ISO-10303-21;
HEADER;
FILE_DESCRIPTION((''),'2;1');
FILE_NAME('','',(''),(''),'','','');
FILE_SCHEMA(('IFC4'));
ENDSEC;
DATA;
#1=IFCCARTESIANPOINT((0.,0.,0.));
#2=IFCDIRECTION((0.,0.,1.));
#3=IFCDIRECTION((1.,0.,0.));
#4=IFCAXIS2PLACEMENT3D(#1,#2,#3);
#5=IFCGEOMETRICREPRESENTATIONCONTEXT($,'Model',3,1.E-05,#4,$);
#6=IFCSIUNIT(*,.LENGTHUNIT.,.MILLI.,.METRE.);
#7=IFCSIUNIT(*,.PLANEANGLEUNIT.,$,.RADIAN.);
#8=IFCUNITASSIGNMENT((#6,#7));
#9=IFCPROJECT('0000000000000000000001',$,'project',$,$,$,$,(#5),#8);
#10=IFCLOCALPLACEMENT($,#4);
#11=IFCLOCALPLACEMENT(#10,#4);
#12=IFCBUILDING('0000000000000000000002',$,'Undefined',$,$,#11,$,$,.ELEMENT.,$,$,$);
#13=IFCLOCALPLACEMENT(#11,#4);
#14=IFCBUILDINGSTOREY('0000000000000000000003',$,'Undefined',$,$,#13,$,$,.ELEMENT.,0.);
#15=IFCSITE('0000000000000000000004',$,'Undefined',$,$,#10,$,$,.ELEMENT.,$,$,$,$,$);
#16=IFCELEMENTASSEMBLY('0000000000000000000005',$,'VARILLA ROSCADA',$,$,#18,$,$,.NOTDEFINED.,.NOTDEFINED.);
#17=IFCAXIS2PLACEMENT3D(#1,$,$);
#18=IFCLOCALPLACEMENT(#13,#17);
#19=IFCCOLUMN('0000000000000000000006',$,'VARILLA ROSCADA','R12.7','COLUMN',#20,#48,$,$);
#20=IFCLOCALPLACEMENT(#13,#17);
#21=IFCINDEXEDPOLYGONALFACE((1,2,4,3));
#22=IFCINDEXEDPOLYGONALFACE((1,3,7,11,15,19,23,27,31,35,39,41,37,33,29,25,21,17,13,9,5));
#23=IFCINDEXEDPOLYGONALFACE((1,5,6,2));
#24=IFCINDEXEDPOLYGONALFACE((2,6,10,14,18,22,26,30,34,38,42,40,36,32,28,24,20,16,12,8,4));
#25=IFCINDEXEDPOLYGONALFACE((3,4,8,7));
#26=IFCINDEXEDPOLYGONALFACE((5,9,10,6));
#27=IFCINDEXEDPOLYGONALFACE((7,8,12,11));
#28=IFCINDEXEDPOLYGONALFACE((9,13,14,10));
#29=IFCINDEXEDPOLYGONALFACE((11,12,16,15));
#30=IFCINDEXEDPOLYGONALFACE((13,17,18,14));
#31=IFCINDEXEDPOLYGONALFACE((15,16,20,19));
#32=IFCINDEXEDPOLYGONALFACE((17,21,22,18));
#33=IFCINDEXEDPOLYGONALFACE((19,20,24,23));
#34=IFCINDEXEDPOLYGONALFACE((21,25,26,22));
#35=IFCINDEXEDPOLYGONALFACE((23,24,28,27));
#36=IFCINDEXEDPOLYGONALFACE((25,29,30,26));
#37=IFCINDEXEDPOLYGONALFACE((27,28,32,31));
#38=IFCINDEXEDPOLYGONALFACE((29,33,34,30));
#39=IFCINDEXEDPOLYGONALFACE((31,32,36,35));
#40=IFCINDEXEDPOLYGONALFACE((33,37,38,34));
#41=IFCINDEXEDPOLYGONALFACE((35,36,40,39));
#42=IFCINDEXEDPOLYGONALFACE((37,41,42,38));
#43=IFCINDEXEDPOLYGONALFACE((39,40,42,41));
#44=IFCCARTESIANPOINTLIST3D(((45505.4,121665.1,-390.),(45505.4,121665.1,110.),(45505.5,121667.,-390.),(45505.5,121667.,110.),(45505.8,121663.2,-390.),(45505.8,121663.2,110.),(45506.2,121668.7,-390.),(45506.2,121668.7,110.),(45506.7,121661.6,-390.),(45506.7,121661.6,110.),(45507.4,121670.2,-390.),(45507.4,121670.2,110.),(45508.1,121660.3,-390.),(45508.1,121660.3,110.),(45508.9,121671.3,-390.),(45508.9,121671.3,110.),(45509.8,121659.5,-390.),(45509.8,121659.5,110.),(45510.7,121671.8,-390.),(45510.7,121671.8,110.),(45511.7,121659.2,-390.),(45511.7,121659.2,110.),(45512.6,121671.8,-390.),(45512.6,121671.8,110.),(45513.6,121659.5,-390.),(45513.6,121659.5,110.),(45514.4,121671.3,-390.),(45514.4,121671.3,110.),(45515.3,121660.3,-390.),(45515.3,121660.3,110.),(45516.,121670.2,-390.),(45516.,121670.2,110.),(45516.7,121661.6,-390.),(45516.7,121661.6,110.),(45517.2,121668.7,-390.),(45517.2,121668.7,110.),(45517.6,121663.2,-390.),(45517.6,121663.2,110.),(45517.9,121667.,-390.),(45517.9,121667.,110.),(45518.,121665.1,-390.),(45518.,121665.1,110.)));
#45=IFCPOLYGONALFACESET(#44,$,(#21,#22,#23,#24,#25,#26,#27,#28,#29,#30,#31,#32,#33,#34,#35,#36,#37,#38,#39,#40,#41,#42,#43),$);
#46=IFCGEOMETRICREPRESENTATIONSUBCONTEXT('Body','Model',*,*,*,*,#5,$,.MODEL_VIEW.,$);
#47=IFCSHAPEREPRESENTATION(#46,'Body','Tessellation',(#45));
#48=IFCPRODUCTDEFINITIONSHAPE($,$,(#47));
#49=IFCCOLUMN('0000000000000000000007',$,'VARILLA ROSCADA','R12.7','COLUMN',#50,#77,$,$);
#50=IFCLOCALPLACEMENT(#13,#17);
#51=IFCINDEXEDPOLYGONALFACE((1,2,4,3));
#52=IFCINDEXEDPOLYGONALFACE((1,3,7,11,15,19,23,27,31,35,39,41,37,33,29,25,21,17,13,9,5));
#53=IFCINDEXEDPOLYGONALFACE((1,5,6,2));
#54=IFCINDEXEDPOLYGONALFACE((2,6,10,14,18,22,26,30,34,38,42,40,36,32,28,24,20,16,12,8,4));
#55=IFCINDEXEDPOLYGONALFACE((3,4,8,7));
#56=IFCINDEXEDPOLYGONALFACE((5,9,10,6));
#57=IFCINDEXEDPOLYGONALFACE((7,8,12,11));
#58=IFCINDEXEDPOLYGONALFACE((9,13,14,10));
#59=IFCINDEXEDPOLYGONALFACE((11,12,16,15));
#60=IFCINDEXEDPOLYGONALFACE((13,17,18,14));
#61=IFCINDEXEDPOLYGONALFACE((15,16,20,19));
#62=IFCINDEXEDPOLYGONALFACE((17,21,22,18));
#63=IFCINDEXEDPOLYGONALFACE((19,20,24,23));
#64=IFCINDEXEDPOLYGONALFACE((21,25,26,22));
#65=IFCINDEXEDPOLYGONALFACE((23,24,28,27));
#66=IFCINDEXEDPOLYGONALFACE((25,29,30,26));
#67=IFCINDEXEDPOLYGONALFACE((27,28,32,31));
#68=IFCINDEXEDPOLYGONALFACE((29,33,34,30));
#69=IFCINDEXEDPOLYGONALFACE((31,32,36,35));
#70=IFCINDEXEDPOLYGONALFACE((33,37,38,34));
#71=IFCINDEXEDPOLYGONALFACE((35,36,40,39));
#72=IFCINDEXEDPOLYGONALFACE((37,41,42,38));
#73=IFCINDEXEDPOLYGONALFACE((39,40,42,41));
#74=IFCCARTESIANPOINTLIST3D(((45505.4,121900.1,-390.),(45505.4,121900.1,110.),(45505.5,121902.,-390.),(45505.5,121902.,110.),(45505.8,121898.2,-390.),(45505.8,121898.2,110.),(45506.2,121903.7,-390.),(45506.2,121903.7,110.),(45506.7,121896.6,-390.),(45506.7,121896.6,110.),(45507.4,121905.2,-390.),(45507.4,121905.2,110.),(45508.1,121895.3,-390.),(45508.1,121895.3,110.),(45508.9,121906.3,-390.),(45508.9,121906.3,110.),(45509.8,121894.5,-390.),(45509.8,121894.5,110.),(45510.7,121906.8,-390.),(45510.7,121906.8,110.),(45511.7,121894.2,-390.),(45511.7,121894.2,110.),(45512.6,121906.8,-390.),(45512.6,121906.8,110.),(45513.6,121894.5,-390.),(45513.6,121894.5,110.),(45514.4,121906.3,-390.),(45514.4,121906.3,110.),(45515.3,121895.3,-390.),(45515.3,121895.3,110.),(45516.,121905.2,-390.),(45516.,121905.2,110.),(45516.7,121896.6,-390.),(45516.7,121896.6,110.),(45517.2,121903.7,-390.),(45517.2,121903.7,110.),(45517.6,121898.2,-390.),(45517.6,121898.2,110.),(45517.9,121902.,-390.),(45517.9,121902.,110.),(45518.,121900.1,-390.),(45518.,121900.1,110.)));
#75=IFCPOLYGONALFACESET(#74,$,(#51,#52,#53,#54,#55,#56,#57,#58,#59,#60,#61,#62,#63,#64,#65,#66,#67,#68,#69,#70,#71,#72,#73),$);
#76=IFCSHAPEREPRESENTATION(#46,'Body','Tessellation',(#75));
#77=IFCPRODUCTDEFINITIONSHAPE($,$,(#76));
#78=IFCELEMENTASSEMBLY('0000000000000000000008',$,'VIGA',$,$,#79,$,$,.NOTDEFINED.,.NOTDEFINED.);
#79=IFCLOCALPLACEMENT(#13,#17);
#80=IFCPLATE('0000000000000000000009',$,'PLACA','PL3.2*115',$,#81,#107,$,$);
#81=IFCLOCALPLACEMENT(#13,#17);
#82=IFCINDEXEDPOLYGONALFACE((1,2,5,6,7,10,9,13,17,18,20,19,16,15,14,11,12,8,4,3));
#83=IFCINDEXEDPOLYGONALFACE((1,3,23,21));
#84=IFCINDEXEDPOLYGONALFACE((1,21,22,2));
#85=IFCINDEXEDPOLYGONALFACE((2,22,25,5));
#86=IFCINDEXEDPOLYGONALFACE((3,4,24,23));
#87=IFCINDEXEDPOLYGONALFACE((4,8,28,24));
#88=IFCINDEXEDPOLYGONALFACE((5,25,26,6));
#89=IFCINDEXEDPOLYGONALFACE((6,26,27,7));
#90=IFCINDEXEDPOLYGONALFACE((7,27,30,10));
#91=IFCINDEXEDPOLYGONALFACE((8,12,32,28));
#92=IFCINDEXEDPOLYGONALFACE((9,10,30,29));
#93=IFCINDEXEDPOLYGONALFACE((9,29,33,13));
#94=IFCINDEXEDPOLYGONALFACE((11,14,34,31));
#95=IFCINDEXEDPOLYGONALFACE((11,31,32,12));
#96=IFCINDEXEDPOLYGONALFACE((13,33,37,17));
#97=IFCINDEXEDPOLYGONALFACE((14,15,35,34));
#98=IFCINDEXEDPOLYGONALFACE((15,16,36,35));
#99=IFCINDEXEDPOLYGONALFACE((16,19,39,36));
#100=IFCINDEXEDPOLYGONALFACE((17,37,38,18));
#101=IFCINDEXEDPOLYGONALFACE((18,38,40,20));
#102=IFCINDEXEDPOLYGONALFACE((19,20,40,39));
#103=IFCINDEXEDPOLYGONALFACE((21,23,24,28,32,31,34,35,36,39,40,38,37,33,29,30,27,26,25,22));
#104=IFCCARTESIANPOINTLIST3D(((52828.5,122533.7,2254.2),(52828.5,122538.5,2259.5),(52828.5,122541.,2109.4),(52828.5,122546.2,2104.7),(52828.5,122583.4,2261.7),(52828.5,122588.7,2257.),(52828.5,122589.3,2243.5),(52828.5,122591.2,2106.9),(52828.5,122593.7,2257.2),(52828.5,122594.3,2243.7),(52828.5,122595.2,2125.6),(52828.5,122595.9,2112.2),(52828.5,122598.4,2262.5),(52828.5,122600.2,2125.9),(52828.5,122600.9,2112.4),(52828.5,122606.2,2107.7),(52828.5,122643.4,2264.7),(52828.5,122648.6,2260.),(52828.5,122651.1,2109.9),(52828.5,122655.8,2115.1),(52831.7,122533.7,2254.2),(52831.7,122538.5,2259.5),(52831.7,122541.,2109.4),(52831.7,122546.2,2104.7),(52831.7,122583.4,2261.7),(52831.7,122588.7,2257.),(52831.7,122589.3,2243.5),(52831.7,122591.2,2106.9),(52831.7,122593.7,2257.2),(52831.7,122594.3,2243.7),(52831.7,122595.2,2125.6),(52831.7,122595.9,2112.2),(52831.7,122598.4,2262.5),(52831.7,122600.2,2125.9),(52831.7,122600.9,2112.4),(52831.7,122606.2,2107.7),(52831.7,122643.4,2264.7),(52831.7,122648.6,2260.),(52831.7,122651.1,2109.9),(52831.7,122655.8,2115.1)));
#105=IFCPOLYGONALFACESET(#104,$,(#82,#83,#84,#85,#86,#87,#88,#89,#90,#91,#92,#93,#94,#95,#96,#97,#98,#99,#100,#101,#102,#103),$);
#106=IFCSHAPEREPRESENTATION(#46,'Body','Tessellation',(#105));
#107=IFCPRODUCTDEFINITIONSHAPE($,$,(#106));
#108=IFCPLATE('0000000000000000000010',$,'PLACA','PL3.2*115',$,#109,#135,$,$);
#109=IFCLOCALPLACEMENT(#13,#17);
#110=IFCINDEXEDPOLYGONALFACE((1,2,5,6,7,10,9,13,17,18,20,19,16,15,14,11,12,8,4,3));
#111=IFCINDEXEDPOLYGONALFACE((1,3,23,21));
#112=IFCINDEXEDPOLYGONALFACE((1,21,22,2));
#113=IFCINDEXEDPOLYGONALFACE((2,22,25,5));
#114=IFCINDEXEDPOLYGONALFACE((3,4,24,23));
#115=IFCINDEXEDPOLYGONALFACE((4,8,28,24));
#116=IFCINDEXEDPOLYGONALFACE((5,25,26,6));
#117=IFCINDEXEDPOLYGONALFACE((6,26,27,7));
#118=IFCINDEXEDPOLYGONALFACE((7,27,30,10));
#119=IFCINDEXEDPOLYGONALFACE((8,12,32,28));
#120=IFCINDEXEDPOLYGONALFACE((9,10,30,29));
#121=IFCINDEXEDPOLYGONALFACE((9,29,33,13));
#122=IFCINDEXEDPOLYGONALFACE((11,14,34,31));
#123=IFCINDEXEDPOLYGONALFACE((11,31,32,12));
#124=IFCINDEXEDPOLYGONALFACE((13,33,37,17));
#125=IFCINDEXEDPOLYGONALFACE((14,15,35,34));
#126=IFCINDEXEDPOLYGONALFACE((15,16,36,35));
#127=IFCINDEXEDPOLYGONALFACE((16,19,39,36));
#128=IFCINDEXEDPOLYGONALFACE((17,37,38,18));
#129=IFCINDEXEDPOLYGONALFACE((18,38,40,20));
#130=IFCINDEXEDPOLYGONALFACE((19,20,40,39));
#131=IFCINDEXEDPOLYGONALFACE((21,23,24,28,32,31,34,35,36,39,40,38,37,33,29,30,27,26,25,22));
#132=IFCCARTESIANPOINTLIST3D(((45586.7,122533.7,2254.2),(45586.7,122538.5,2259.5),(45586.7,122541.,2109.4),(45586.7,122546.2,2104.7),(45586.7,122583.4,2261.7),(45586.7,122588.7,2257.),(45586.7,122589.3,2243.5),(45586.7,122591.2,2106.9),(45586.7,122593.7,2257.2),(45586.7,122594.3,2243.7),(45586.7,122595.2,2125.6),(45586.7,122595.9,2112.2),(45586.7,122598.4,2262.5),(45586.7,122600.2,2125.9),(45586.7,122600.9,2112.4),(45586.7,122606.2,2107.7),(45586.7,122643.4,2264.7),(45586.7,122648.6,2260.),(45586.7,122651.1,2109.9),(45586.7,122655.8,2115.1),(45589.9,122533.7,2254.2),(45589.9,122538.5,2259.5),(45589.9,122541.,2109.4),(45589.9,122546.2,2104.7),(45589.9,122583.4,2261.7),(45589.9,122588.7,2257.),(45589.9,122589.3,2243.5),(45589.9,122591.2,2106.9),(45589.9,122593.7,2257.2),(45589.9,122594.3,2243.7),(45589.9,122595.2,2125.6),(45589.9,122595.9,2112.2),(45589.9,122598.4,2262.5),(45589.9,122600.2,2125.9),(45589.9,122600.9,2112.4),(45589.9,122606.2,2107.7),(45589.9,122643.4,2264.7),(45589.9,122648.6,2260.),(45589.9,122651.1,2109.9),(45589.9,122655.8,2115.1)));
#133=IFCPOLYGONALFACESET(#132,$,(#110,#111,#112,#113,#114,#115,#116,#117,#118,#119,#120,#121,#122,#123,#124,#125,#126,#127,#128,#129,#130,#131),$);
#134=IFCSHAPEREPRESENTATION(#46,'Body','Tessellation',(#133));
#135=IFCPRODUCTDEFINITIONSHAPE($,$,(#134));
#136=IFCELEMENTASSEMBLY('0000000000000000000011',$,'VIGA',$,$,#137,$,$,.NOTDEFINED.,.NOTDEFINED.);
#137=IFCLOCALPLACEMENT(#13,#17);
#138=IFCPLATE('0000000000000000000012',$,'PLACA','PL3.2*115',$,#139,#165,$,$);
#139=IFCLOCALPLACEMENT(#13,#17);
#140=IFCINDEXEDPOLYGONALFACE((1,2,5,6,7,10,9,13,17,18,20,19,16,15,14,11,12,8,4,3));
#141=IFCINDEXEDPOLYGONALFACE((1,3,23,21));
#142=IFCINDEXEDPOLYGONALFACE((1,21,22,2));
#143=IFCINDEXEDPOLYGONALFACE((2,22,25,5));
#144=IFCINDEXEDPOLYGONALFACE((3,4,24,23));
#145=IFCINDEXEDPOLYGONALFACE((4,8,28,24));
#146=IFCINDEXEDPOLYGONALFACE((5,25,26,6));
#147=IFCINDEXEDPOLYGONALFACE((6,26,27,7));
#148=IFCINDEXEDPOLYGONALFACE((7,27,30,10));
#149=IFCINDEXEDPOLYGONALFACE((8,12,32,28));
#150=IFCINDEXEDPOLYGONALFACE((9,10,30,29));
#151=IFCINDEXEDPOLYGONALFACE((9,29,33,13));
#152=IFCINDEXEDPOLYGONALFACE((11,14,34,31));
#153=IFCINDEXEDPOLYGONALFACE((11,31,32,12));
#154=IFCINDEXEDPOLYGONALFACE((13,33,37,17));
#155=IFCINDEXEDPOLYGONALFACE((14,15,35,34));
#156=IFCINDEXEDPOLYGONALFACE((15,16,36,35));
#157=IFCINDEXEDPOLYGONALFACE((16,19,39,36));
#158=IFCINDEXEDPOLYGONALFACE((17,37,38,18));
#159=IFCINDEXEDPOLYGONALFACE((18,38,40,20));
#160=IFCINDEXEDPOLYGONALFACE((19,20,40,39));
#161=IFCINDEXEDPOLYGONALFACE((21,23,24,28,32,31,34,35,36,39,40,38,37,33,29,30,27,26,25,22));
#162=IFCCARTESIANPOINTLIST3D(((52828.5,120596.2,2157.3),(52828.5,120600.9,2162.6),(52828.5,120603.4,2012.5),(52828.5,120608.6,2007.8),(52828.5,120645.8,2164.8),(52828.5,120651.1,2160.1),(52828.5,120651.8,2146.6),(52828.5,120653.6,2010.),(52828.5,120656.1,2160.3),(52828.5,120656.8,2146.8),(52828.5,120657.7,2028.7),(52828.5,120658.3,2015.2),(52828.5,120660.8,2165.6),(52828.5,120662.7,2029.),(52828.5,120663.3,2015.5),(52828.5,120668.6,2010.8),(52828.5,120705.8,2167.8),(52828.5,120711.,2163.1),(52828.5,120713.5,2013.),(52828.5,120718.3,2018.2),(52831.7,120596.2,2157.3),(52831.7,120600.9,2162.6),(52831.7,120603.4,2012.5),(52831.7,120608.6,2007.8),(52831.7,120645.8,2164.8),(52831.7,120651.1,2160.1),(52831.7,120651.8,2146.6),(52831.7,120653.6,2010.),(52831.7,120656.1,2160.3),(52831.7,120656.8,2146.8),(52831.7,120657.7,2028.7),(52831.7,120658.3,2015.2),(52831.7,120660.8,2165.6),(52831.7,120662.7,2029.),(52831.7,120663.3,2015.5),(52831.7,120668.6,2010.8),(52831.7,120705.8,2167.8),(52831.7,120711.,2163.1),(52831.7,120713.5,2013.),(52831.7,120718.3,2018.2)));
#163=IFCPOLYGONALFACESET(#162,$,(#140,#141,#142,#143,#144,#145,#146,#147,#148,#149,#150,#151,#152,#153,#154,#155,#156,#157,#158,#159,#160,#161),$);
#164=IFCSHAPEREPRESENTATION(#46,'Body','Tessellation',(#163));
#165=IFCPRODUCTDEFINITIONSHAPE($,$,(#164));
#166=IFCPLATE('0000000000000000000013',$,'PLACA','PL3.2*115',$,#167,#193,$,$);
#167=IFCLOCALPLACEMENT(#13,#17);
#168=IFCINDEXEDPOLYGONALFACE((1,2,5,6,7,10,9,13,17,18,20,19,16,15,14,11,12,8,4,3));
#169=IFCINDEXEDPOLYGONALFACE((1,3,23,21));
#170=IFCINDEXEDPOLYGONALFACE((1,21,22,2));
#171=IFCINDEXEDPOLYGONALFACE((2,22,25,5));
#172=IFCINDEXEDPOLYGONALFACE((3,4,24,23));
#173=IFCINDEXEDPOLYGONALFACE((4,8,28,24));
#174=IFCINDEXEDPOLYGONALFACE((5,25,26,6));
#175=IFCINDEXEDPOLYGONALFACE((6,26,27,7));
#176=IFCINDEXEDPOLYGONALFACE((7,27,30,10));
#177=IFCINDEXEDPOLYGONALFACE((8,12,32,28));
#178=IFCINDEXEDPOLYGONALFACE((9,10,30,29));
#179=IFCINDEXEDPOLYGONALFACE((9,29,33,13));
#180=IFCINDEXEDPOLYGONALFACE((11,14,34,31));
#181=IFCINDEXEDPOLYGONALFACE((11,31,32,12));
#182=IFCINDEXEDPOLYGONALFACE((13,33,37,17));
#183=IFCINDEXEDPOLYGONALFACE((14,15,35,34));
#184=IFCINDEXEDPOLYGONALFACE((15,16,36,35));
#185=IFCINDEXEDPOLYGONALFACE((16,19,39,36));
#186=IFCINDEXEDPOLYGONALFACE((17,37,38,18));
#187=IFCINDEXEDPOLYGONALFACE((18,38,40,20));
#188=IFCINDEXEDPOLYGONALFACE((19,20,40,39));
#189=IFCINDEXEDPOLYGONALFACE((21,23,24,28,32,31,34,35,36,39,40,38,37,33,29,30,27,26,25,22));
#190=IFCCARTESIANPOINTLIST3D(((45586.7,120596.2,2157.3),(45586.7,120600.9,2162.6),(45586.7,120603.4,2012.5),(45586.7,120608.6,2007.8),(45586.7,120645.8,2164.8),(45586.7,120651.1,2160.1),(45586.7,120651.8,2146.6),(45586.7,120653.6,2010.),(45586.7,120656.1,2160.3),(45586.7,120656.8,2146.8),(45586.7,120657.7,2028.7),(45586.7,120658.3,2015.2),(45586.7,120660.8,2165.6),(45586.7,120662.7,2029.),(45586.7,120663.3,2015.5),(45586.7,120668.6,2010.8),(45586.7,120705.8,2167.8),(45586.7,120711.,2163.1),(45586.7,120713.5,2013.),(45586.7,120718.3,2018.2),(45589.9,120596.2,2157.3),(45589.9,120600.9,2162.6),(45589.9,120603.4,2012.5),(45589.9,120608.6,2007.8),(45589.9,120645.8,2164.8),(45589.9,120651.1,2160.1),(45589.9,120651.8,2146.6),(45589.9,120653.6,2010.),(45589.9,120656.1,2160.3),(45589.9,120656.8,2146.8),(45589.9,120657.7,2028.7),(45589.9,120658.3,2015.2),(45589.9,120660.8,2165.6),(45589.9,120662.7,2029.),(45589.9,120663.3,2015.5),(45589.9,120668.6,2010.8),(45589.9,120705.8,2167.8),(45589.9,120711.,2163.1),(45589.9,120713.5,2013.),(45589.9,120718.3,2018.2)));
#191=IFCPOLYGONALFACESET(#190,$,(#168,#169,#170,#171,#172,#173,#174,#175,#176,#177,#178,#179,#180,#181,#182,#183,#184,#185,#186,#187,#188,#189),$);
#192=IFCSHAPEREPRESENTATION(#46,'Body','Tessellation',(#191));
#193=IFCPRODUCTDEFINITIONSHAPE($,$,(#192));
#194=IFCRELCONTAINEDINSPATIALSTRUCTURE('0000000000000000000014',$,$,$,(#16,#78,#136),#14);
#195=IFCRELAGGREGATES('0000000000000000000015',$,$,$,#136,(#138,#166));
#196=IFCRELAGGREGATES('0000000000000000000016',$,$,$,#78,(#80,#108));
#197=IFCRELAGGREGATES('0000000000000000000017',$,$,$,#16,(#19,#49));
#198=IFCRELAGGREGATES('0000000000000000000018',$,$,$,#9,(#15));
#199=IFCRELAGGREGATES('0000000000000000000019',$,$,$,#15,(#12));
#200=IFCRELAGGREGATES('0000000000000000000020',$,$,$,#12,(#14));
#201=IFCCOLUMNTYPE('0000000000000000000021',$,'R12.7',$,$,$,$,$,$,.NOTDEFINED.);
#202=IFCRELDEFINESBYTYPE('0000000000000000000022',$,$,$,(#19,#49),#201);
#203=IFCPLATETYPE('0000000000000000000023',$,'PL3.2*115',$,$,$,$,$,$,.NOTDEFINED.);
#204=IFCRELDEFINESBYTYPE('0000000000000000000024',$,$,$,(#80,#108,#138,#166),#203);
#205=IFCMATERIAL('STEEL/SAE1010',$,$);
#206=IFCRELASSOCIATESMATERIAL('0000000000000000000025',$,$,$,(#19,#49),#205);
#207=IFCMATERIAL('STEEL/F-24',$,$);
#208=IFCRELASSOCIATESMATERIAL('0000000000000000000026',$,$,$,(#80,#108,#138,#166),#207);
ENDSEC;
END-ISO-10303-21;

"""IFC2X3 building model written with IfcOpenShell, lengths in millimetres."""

from ifc_helpers import new_model, si_unit, frame, origin_with_axes, origin_2d_with_axis, place, context, subcontext, project, spatial, polyline, circle, outline, extrude, material, type_object, element, aggregate, save


model = new_model("IFC2X3")

# Units and contexts
model_context = context("Model", 3, precision=1e-05, world=origin_with_axes())
body_context = subcontext(model_context, "Body", "Model", "MODEL_VIEW")
ifc_project = project(units=[si_unit("LENGTHUNIT", "METRE", prefix="MILLI"), si_unit("PLANEANGLEUNIT", "RADIAN")], contexts=[model_context])

# Site, building, storey
site_placement = place(None, origin_with_axes())
site = spatial("IfcSite", under=ifc_project, at=site_placement, Name="Undefined", CompositionType="ELEMENT")
building_placement = place(site_placement, origin_with_axes())
building = spatial("IfcBuilding", under=site, at=building_placement, Name="Undefined", CompositionType="ELEMENT")
storey_placement = place(building_placement, origin_with_axes())
storey = spatial("IfcBuildingStorey", under=building, at=storey_placement, Name="Undefined", CompositionType="ELEMENT", Elevation=0.0)

# Element assembly, columns
assembly_1_placement = place(storey_placement, origin_with_axes())
assembly_1 = element("IfcElementAssembly", 1, at=assembly_1_placement, inside=storey, Name="VARILLA ROSCADA", AssemblyPlace="NOTDEFINED", PredefinedType="NOTDEFINED")
ifc_material_1 = material(Name="STEEL/SAE1010")
column_type = type_object("IfcColumnType", Name="R12.7", PredefinedType="NOTDEFINED")
column_1_placement = place(assembly_1_placement, frame((45511.7, 121665.6, -390.0), z_axis=(0.0, 0.0, 1.0), x_axis=(-1.0, 0.0, 0.0)))
column_1 = element("IfcColumn", 2, at=column_1_placement, type_object=column_type, material=ifc_material_1, Name="VARILLA ROSCADA", Description="R12.7", ObjectType="COLUMN", context=body_context, shape_type="SweptSolid", body=[
    extrude(circle(Radius=6.3, at=origin_2d_with_axis()), frame((0.0, 0.0, 500.0), z_axis=(0.0, 0.0, -1.0), x_axis=(0.0, 1.0, 0.0)), (0.0, 0.0, 1.0), 500.0),
])
column_2_placement = place(assembly_1_placement, frame((45511.7, 121900.6, -390.0), z_axis=(0.0, 0.0, 1.0), x_axis=(-1.0, 0.0, 0.0)))
column_2 = element("IfcColumn", 3, at=column_2_placement, type_object=column_type, material=ifc_material_1, Name="VARILLA ROSCADA", Description="R12.7", ObjectType="COLUMN", context=body_context, shape_type="SweptSolid", body=[
    extrude(circle(Radius=6.3, at=origin_2d_with_axis()), frame((0.0, 0.0, 500.0), z_axis=(0.0, 0.0, -1.0), x_axis=(0.0, 1.0, 0.0)), (0.0, 0.0, 1.0), 500.0),
])

# Element assemblies, plates
assembly_2_placement = place(storey_placement, origin_with_axes())
assembly_2 = element("IfcElementAssembly", 4, at=assembly_2_placement, inside=storey, Name="VIGA", AssemblyPlace="NOTDEFINED", PredefinedType="NOTDEFINED")
ifc_material_2 = material(Name="STEEL/F-24")
plate_type_1 = type_object("IfcPlateType", Name="PL3.2*115", PredefinedType="NOTDEFINED")
plate_1_placement = place(assembly_2_placement, frame((52830.1, 122533.5, 2259.2), z_axis=(-1.0, 0.0, 0.0), x_axis=(0.0, 0.998752, 0.04995)))
plate_1 = element("IfcPlate", 5, at=plate_1_placement, type_object=plate_type_1, material=ifc_material_2, Name="PLACA", Description="PL3.2*115", context=body_context, shape_type="SweptSolid", body=[
    extrude(outline(polyline([(0.0, 5.0), (5.0, 0.0), (50.0, 0.0), (55.0, 5.0), (55.0, 18.5), (60.0, 18.5), (60.0, 5.0), (65.0, 0.0), (110.0, 0.0), (115.0, 5.0), (115.0, 150.0), (110.0, 155.0), (65.0, 155.0), (60.0, 150.0), (60.0, 136.5), (55.0, 136.5), (55.0, 150.0), (50.0, 155.0), (5.0, 155.0), (0.0, 150.0), (0.0, 5.0)])), frame((0.0, 0.0, -1.6), z_axis=(0.0, 0.0, 1.0), x_axis=(1.0, 0.0, 0.0)), (0.0, 0.0, 1.0), 3.2),
])
plate_2_placement = place(assembly_2_placement, frame((45588.3, 122533.5, 2259.2), z_axis=(-1.0, 0.0, 0.0), x_axis=(0.0, 0.998752, 0.04995)))
plate_2 = element("IfcPlate", 6, at=plate_2_placement, type_object=plate_type_1, material=ifc_material_2, Name="PLACA", Description="PL3.2*115", context=body_context, shape_type="SweptSolid", body=[
    extrude(outline(polyline([(0.0, 5.0), (5.0, 0.0), (50.0, 0.0), (55.0, 5.0), (55.0, 18.5), (60.0, 18.5), (60.0, 5.0), (65.0, 0.0), (110.0, 0.0), (115.0, 5.0), (115.0, 150.0), (110.0, 155.0), (65.0, 155.0), (60.0, 150.0), (60.0, 136.5), (55.0, 136.5), (55.0, 150.0), (50.0, 155.0), (5.0, 155.0), (0.0, 150.0), (0.0, 5.0)])), frame((0.0, 0.0, -1.6), z_axis=(0.0, 0.0, 1.0), x_axis=(1.0, 0.0, 0.0)), (0.0, 0.0, 1.0), 3.2),
])
assembly_3_placement = place(storey_placement, origin_with_axes())
assembly_3 = element("IfcElementAssembly", 7, at=assembly_3_placement, inside=storey, Name="VIGA", AssemblyPlace="NOTDEFINED", PredefinedType="NOTDEFINED")
plate_3_placement = place(assembly_3_placement, frame((52830.1, 120595.9, 2162.3), z_axis=(-1.0, 0.0, 0.0), x_axis=(0.0, 0.998752, 0.04995)))
plate_3 = element("IfcPlate", 8, at=plate_3_placement, type_object=plate_type_1, material=ifc_material_2, Name="PLACA", Description="PL3.2*115", context=body_context, shape_type="SweptSolid", body=[
    extrude(outline(polyline([(0.0, 5.0), (5.0, 0.0), (50.0, 0.0), (55.0, 5.0), (55.0, 18.5), (60.0, 18.5), (60.0, 5.0), (65.0, 0.0), (110.0, 0.0), (115.0, 5.0), (115.0, 150.0), (110.0, 155.0), (65.0, 155.0), (60.0, 150.0), (60.0, 136.5), (55.0, 136.5), (55.0, 150.0), (50.0, 155.0), (5.0, 155.0), (0.0, 150.0), (0.0, 5.0)])), frame((0.0, 0.0, -1.6), z_axis=(0.0, 0.0, 1.0), x_axis=(1.0, 0.0, 0.0)), (0.0, 0.0, 1.0), 3.2),
])
plate_4_placement = place(assembly_3_placement, frame((45588.3, 120595.9, 2162.3), z_axis=(-1.0, 0.0, 0.0), x_axis=(0.0, 0.998752, 0.04995)))
plate_4 = element("IfcPlate", 9, at=plate_4_placement, type_object=plate_type_1, material=ifc_material_2, Name="PLACA", Description="PL3.2*115", context=body_context, shape_type="SweptSolid", body=[
    extrude(outline(polyline([(0.0, 5.0), (5.0, 0.0), (50.0, 0.0), (55.0, 5.0), (55.0, 18.5), (60.0, 18.5), (60.0, 5.0), (65.0, 0.0), (110.0, 0.0), (115.0, 5.0), (115.0, 150.0), (110.0, 155.0), (65.0, 155.0), (60.0, 150.0), (60.0, 136.5), (55.0, 136.5), (55.0, 150.0), (50.0, 155.0), (5.0, 155.0), (0.0, 150.0), (0.0, 5.0)])), frame((0.0, 0.0, -1.6), z_axis=(0.0, 0.0, 1.0), x_axis=(1.0, 0.0, 0.0)), (0.0, 0.0, 1.0), 3.2),
])

aggregate(assembly_3, [plate_3, plate_4])
aggregate(assembly_2, [plate_1, plate_2])
aggregate(assembly_1, [column_1, column_2])

save(model, "model.ifc")
